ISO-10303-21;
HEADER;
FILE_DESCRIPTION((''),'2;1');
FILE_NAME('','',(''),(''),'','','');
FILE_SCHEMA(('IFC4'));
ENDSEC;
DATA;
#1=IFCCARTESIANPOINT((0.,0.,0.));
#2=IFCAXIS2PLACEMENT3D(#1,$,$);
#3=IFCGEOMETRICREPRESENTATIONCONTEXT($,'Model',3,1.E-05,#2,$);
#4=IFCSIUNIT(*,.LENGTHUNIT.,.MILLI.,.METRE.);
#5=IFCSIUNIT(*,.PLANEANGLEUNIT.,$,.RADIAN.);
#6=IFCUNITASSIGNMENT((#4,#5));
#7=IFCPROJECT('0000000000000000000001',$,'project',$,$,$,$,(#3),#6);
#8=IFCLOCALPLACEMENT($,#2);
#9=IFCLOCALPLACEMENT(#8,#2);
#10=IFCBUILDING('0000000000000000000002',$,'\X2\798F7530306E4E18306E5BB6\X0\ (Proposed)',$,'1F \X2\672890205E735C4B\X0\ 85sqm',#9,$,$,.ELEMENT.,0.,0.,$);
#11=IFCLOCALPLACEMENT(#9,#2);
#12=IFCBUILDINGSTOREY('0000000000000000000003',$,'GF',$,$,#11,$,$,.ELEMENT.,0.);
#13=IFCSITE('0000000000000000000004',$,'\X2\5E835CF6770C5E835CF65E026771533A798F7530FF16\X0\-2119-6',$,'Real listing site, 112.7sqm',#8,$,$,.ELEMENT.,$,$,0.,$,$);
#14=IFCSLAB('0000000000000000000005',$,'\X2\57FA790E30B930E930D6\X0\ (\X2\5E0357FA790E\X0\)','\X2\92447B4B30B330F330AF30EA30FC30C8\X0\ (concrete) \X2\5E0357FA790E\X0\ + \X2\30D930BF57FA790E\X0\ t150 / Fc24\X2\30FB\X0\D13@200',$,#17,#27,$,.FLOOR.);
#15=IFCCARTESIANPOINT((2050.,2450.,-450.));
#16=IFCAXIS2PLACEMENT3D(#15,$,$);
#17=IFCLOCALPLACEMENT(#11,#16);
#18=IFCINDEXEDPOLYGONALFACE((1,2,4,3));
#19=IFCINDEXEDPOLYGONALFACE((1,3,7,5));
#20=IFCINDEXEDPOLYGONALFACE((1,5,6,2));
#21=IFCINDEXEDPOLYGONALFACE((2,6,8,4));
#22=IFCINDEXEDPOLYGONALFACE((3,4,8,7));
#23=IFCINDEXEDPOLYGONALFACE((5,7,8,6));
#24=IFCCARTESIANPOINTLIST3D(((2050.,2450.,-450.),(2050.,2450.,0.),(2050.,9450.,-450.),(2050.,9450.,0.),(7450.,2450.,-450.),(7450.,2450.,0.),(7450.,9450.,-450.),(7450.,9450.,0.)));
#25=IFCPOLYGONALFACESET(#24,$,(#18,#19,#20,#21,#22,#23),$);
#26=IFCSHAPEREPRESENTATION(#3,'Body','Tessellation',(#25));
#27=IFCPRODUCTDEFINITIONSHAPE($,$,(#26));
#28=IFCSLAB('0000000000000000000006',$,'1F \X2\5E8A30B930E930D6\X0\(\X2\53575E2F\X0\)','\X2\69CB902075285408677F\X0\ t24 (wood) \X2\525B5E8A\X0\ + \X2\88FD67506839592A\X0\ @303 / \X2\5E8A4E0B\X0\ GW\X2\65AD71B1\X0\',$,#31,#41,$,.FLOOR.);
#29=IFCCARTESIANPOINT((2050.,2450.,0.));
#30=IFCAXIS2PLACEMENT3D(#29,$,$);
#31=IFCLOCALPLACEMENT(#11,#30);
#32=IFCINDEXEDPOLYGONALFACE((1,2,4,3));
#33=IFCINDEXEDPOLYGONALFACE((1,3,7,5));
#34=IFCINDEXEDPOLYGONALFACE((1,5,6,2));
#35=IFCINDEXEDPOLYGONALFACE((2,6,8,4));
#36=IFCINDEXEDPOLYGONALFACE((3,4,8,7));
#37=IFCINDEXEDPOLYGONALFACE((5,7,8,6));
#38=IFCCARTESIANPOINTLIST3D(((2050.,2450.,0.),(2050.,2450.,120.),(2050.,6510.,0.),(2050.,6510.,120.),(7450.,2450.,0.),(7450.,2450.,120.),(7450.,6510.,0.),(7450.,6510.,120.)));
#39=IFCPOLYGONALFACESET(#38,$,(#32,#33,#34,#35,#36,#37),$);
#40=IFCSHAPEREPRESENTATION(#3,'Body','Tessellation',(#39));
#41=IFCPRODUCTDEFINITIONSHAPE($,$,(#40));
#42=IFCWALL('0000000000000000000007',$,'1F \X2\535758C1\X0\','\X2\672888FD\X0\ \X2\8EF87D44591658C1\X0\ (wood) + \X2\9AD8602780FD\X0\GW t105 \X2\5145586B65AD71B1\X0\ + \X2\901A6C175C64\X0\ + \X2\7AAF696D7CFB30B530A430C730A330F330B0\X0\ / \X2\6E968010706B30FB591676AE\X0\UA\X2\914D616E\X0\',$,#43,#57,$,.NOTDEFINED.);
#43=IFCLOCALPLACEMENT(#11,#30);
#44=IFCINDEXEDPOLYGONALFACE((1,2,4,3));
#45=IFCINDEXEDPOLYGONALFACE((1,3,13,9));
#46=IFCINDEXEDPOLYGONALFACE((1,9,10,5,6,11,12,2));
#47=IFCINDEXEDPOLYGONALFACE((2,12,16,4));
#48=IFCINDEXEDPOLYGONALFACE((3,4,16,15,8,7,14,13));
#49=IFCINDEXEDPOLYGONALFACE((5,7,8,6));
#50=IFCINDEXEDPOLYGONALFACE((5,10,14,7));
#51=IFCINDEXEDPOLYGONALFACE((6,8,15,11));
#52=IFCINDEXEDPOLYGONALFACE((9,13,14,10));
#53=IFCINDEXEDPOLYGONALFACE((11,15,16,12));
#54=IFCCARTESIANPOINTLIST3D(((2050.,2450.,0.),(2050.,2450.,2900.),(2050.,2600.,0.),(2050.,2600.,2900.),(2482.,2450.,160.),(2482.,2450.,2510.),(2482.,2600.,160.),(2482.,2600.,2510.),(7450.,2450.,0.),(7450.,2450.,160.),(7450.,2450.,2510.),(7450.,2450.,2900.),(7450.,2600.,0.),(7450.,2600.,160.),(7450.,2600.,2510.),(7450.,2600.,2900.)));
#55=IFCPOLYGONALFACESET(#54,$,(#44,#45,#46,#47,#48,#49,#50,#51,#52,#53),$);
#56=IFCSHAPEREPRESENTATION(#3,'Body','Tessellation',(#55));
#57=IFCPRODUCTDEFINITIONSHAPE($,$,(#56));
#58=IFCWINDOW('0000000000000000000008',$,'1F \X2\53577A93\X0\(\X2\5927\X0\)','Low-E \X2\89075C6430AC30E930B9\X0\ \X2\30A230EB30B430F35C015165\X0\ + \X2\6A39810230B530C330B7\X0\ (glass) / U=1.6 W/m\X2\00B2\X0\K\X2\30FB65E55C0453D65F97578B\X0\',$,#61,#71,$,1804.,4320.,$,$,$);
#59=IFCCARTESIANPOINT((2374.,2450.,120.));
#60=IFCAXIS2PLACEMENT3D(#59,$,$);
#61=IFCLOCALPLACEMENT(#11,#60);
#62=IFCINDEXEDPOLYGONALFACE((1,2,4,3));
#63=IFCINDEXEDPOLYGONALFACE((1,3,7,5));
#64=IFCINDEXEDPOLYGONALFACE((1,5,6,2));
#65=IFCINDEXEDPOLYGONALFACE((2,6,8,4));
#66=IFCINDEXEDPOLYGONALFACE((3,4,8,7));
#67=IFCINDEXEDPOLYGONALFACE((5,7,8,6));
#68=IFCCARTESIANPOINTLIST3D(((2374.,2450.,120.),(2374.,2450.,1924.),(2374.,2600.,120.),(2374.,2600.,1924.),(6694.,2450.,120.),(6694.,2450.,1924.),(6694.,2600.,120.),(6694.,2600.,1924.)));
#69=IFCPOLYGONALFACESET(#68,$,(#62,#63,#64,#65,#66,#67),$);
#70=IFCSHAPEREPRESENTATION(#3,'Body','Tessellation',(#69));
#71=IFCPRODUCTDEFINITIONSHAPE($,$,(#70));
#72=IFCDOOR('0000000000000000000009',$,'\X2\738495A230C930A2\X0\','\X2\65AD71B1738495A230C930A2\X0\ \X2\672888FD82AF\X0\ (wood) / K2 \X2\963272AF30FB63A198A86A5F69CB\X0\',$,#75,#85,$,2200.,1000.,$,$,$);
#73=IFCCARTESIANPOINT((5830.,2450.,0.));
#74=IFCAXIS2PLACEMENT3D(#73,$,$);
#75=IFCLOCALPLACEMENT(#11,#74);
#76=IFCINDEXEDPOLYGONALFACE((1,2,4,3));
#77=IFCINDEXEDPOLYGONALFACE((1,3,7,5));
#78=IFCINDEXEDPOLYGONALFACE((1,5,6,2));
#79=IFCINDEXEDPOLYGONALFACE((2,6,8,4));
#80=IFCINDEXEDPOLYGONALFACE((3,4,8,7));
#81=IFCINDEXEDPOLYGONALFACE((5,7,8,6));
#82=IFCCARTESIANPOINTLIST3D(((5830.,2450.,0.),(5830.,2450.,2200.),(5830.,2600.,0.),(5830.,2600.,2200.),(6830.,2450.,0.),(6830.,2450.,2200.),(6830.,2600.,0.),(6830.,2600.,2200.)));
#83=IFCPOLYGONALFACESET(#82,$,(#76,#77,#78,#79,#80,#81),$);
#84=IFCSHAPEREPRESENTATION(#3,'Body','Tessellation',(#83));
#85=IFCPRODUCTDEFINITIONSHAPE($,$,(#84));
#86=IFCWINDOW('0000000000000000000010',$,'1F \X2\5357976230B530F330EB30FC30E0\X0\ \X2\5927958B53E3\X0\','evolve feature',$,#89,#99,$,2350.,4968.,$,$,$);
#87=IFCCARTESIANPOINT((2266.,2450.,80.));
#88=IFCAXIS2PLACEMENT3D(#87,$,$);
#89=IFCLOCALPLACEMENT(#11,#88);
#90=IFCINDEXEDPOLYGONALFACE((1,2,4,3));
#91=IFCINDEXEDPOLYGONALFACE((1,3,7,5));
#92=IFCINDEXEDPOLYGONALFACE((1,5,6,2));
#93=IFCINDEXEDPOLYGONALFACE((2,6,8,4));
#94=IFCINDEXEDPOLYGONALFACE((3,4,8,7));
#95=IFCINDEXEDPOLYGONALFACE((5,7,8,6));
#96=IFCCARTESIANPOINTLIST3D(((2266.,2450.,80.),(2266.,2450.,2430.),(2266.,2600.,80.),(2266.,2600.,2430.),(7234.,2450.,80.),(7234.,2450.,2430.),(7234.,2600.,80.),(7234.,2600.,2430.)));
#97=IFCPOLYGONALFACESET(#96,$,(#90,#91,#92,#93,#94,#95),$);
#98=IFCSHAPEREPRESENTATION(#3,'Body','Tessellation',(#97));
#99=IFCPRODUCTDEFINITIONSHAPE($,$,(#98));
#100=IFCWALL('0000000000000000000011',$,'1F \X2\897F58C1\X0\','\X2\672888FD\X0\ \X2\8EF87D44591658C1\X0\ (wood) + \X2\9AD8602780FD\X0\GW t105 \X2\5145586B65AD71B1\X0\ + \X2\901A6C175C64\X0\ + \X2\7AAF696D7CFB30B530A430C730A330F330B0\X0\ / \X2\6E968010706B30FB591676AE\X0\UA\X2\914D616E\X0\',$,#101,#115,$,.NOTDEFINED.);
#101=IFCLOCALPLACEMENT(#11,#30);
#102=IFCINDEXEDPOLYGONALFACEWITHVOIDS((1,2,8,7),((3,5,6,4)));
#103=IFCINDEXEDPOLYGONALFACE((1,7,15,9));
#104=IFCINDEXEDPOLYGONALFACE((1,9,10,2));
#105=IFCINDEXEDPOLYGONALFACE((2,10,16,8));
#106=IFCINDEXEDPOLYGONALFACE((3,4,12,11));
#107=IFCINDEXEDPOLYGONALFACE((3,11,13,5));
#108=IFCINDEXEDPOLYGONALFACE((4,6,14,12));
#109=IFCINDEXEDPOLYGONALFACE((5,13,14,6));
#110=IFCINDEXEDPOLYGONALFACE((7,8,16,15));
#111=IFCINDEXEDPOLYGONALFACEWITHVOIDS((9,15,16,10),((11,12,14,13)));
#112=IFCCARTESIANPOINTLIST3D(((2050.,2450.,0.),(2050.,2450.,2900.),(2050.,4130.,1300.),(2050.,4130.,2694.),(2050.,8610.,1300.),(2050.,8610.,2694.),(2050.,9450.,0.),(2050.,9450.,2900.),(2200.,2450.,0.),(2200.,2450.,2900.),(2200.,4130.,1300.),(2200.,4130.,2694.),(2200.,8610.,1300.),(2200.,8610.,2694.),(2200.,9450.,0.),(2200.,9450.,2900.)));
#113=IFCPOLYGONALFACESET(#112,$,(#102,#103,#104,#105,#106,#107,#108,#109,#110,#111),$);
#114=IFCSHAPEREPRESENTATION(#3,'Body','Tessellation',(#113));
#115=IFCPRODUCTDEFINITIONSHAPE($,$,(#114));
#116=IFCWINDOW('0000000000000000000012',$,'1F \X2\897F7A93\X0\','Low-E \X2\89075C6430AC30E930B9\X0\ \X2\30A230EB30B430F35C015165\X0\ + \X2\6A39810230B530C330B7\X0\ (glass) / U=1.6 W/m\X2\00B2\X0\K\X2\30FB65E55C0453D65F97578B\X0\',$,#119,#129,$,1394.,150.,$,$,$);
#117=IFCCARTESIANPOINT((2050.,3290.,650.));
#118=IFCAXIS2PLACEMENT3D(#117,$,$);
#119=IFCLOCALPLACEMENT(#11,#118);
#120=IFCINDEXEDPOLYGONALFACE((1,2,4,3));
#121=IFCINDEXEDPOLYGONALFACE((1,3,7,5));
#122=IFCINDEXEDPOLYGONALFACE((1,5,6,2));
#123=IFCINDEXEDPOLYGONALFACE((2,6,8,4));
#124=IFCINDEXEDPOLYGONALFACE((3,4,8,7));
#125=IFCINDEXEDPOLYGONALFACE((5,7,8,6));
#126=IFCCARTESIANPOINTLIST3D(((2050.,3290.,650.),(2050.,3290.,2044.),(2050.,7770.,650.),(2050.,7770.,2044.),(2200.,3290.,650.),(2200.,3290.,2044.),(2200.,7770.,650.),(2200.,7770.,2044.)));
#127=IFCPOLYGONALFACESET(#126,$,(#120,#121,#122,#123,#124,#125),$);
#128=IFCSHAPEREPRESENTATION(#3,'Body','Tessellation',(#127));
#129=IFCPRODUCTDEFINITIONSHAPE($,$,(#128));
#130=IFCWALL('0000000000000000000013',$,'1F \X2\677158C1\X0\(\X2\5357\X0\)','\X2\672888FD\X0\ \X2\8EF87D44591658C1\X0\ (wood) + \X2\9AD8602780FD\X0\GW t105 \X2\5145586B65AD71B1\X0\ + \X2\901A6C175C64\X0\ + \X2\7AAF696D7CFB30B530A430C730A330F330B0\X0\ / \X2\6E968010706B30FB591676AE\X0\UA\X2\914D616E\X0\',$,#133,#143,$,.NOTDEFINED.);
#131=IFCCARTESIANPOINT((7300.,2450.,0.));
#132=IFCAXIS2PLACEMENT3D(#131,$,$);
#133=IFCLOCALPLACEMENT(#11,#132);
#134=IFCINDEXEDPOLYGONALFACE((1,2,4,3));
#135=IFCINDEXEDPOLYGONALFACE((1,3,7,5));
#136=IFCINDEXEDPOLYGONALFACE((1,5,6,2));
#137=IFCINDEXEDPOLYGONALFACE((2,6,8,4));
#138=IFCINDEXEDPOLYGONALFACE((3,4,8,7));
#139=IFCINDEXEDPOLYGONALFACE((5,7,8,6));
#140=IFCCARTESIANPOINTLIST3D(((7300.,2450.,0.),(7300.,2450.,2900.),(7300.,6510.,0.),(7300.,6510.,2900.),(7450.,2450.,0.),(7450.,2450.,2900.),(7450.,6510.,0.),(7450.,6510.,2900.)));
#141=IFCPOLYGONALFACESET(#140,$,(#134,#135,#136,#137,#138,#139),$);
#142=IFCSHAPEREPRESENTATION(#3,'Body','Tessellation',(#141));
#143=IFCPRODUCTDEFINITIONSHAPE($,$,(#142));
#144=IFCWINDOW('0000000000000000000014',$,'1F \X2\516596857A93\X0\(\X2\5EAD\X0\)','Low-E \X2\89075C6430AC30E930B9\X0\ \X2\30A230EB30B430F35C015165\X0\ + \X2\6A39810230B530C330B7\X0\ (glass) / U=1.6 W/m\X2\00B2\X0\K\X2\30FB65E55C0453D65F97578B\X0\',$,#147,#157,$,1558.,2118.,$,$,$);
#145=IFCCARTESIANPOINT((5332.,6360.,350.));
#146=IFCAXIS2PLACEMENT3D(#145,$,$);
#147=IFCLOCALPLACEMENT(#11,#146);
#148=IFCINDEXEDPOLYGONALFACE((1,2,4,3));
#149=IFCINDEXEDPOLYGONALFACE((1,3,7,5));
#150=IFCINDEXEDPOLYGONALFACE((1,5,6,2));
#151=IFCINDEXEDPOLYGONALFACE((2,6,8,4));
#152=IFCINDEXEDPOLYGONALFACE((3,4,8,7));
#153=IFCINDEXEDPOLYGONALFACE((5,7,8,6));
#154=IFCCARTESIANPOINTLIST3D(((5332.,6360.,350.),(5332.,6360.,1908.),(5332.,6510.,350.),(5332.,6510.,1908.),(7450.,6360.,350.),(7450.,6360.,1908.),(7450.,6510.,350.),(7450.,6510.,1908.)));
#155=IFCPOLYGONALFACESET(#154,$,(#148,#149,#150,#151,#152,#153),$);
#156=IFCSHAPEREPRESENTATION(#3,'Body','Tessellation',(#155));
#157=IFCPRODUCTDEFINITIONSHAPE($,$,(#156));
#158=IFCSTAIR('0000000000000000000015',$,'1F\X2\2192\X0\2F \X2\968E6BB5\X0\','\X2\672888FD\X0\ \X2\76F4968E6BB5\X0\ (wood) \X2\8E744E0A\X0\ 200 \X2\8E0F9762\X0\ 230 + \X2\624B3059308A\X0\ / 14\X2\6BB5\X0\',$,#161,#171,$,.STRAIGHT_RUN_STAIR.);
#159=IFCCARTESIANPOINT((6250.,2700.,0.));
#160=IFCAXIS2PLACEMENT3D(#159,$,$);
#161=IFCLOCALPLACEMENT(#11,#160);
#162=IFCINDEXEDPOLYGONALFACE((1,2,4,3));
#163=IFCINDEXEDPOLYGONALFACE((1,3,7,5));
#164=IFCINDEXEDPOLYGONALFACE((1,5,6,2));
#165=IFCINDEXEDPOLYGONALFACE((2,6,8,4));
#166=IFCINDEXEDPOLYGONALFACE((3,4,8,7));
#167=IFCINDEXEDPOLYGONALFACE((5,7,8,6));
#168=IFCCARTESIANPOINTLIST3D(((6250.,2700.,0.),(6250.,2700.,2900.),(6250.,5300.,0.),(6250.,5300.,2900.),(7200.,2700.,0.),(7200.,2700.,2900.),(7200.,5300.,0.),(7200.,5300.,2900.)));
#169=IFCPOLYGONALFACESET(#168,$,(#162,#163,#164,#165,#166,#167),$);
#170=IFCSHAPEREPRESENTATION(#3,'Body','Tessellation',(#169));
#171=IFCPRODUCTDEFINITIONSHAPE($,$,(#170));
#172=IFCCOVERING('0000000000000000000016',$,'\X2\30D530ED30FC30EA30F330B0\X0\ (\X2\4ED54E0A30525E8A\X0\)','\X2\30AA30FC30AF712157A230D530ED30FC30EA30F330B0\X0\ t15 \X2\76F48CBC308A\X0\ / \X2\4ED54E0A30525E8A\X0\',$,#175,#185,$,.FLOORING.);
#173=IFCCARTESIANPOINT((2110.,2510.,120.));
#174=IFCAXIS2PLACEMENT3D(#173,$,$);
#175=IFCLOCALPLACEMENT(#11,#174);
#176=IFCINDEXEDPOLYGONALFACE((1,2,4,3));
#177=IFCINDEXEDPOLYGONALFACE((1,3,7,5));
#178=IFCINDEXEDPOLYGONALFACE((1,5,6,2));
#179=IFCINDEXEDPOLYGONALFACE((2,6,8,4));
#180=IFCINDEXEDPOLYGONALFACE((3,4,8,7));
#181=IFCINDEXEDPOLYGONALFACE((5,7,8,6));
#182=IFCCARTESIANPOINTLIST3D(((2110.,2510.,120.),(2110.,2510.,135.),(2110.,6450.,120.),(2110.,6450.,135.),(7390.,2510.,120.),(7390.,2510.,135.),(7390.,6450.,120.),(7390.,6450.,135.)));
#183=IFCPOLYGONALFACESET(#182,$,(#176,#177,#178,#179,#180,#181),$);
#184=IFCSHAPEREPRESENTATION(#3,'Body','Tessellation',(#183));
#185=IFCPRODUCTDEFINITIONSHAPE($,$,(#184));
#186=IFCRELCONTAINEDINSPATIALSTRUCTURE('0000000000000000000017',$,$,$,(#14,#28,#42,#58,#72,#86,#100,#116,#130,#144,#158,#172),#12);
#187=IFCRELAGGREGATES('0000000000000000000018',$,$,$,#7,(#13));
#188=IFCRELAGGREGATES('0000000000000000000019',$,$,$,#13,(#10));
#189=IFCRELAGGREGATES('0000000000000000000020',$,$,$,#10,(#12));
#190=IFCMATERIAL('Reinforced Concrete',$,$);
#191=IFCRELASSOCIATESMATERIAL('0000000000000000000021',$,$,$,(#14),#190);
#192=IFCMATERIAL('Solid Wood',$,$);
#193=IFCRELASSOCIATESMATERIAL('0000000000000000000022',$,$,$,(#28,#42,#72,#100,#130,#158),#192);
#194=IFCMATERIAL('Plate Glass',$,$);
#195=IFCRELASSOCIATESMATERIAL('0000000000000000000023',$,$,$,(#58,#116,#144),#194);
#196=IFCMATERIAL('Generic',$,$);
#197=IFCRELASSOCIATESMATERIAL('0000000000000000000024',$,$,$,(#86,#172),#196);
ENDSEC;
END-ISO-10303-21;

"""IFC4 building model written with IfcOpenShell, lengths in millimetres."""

from ifc_helpers import new_model, si_unit, frame, frame_2d, origin, place, context, project, spatial, rectangle, extrude, material, element, fill, save


model = new_model("IFC4")

# Units and contexts
model_context = context("Model", 3, precision=1e-05, world=origin())
ifc_project = project(units=[si_unit("LENGTHUNIT", "METRE", prefix="MILLI"), si_unit("PLANEANGLEUNIT", "RADIAN")], contexts=[model_context])

# Site, building, storey
site_placement = place(None, origin())
site = spatial("IfcSite", under=ifc_project, at=site_placement, Name="広島県広島市東区福田６-2119-6", ObjectType="Real listing site, 112.7sqm", CompositionType="ELEMENT", RefElevation=0.0)
building_placement = place(site_placement, origin())
building = spatial("IfcBuilding", under=site, at=building_placement, Name="福田の丘の家 (Proposed)", ObjectType="1F 木造平屋 85sqm", CompositionType="ELEMENT", ElevationOfRefHeight=0.0, ElevationOfTerrain=0.0)
storey_placement = place(building_placement, origin())
storey = spatial("IfcBuildingStorey", under=building, at=storey_placement, Name="GF", CompositionType="ELEMENT", Elevation=0.0)

# Slabs
ifc_material_1 = material(Name="Reinforced Concrete")
slab_1_placement = place(storey_placement, frame((2050.0, 2450.0, -450.0)))
element("IfcSlab", 1, at=slab_1_placement, inside=storey, material=ifc_material_1, Name="基礎スラブ (布基礎)", Description="鉄筋コンクリート (concrete) 布基礎 + ベタ基礎 t150 / Fc24・D13@200", PredefinedType="FLOOR", context=model_context, shape_type="SweptSolid", body=[
    extrude(rectangle(XDim=5400.0, YDim=7000.0, at=frame_2d((2700.0, 3500.0))), frame((2050.0, 2450.0, -450.0)), (0.0, 0.0, 1.0), 450.0),
])
ifc_material_2 = material(Name="Solid Wood")
slab_2_placement = place(storey_placement, frame((2050.0, 2450.0, 0.0)))
element("IfcSlab", 2, at=slab_2_placement, inside=storey, material=ifc_material_2, Name="1F 床スラブ(南帯)", Description="構造用合板 t24 (wood) 剛床 + 製材根太 @303 / 床下 GW断熱", PredefinedType="FLOOR", context=model_context, shape_type="SweptSolid", body=[
    extrude(rectangle(XDim=5400.0, YDim=4060.0, at=frame_2d((2700.0, 2030.0))), frame((2050.0, 2450.0, 0.0)), (0.0, 0.0, 1.0), 120.0),
])

# Wall, openings, windows, door
wall_1_placement = place(storey_placement, frame((2050.0, 2450.0, 0.0)))
wall_1 = element("IfcWall", 3, at=wall_1_placement, inside=storey, material=ifc_material_2, Name="1F 南壁", Description="木製 軸組外壁 (wood) + 高性能GW t105 充填断熱 + 通気層 + 窯業系サイディング / 準耐火・外皮UA配慮", PredefinedType="NOTDEFINED", context=model_context, shape_type="SweptSolid", body=[
    extrude(rectangle(XDim=5400.0, YDim=150.0, at=frame_2d((2700.0, 75.0))), frame((2050.0, 2450.0, 0.0)), (0.0, 0.0, 1.0), 2900.0),
])
opening_1_placement = place(storey_placement, frame((2374.0, 2450.0, 120.0)))
opening_1 = element("IfcOpeningElement", 4, at=opening_1_placement, cuts=wall_1, PredefinedType="NOTDEFINED", context=model_context, shape_type="SweptSolid", body=[
    extrude(rectangle(XDim=4320.0, YDim=150.0, at=frame_2d((2160.0, 75.0))), frame((2374.0, 2450.0, 120.0)), (0.0, 0.0, 1.0), 1804.0),
])
opening_2_placement = place(storey_placement, frame((5830.0, 2450.0, 0.0)))
opening_2 = element("IfcOpeningElement", 5, at=opening_2_placement, cuts=wall_1, PredefinedType="NOTDEFINED", context=model_context, shape_type="SweptSolid", body=[
    extrude(rectangle(XDim=1000.0, YDim=150.0, at=frame_2d((500.0, 75.0))), frame((5830.0, 2450.0, 0.0)), (0.0, 0.0, 1.0), 2200.0),
])
opening_3_placement = place(storey_placement, frame((2266.0, 2450.0, 80.0)))
opening_3 = element("IfcOpeningElement", 6, at=opening_3_placement, cuts=wall_1, PredefinedType="NOTDEFINED", context=model_context, shape_type="SweptSolid", body=[
    extrude(rectangle(XDim=4968.0, YDim=150.0, at=frame_2d((2484.0, 75.0))), frame((2266.0, 2450.0, 80.0)), (0.0, 0.0, 1.0), 2350.0),
])
ifc_material_3 = material(Name="Plate Glass")
window_1_placement = place(storey_placement, frame((2374.0, 2450.0, 120.0)))
window_1 = element("IfcWindow", 7, at=window_1_placement, inside=storey, material=ifc_material_3, Name="1F 南窓(大)", Description="Low-E 複層ガラス アルゴン封入 + 樹脂サッシ (glass) / U=1.6 W/m²K・日射取得型", OverallHeight=1804.0, OverallWidth=4320.0, context=model_context, shape_type="SweptSolid", body=[
    extrude(rectangle(XDim=4320.0, YDim=150.0, at=frame_2d((2160.0, 75.0))), frame((2374.0, 2450.0, 120.0)), (0.0, 0.0, 1.0), 1804.0),
])
fill(opening_1, window_1)
door_1_placement = place(storey_placement, frame((5830.0, 2450.0, 0.0)))
door_1 = element("IfcDoor", 8, at=door_1_placement, inside=storey, material=ifc_material_2, Name="玄関ドア", Description="断熱玄関ドア 木製芯 (wood) / K2 防犯・採風機構", OverallHeight=2200.0, OverallWidth=1000.0, context=model_context, shape_type="SweptSolid", body=[
    extrude(rectangle(XDim=1000.0, YDim=150.0, at=frame_2d((500.0, 75.0))), frame((5830.0, 2450.0, 0.0)), (0.0, 0.0, 1.0), 2200.0),
])
fill(opening_2, door_1)
ifc_material_4 = material(Name="Generic")
window_2_placement = place(storey_placement, frame((2266.0, 2450.0, 80.0)))
window_2 = element("IfcWindow", 9, at=window_2_placement, inside=storey, material=ifc_material_4, Name="1F 南面サンルーム 大開口", Description="evolve feature", OverallHeight=2350.0, OverallWidth=4968.0, context=model_context, shape_type="SweptSolid", body=[
    extrude(rectangle(XDim=4968.0, YDim=150.0, at=frame_2d((2484.0, 75.0))), frame((2266.0, 2450.0, 80.0)), (0.0, 0.0, 1.0), 2350.0),
])
fill(opening_3, window_2)

# Walls, openings, windows
wall_2_placement = place(storey_placement, frame((2050.0, 2450.0, 0.0)))
wall_2 = element("IfcWall", 10, at=wall_2_placement, inside=storey, material=ifc_material_2, Name="1F 西壁", Description="木製 軸組外壁 (wood) + 高性能GW t105 充填断熱 + 通気層 + 窯業系サイディング / 準耐火・外皮UA配慮", PredefinedType="NOTDEFINED", context=model_context, shape_type="SweptSolid", body=[
    extrude(rectangle(XDim=150.0, YDim=7000.0, at=frame_2d((75.0, 3500.0))), frame((2050.0, 2450.0, 0.0)), (0.0, 0.0, 1.0), 2900.0),
])
opening_4_placement = place(storey_placement, frame((2050.0, 3290.0, 650.0)))
opening_4 = element("IfcOpeningElement", 11, at=opening_4_placement, cuts=wall_2, PredefinedType="NOTDEFINED", context=model_context, shape_type="SweptSolid", body=[
    extrude(rectangle(XDim=150.0, YDim=4480.0, at=frame_2d((75.0, 2240.0))), frame((2050.0, 3290.0, 650.0)), (0.0, 0.0, 1.0), 1394.0),
])
window_3_placement = place(storey_placement, frame((2050.0, 3290.0, 650.0)))
window_3 = element("IfcWindow", 12, at=window_3_placement, inside=storey, material=ifc_material_3, Name="1F 西窓", Description="Low-E 複層ガラス アルゴン封入 + 樹脂サッシ (glass) / U=1.6 W/m²K・日射取得型", OverallHeight=1394.0, OverallWidth=150.0, context=model_context, shape_type="SweptSolid", body=[
    extrude(rectangle(XDim=150.0, YDim=4480.0, at=frame_2d((75.0, 2240.0))), frame((2050.0, 3290.0, 650.0)), (0.0, 0.0, 1.0), 1394.0),
])
fill(opening_4, window_3)
wall_3_placement = place(storey_placement, frame((7300.0, 2450.0, 0.0)))
wall_3 = element("IfcWall", 13, at=wall_3_placement, inside=storey, material=ifc_material_2, Name="1F 東壁(南)", Description="木製 軸組外壁 (wood) + 高性能GW t105 充填断熱 + 通気層 + 窯業系サイディング / 準耐火・外皮UA配慮", PredefinedType="NOTDEFINED", context=model_context, shape_type="SweptSolid", body=[
    extrude(rectangle(XDim=150.0, YDim=4060.0, at=frame_2d((75.0, 2030.0))), frame((7300.0, 2450.0, 0.0)), (0.0, 0.0, 1.0), 2900.0),
])
opening_5_placement = place(storey_placement, frame((5332.0, 6360.0, 350.0)))
opening_5 = element("IfcOpeningElement", 14, at=opening_5_placement, cuts=wall_3, PredefinedType="NOTDEFINED", context=model_context, shape_type="SweptSolid", body=[
    extrude(rectangle(XDim=2118.0, YDim=150.0, at=frame_2d((1059.0, 75.0))), frame((5332.0, 6360.0, 350.0)), (0.0, 0.0, 1.0), 1558.0),
])
window_4_placement = place(storey_placement, frame((5332.0, 6360.0, 350.0)))
window_4 = element("IfcWindow", 15, at=window_4_placement, inside=storey, material=ifc_material_3, Name="1F 入隅窓(庭)", Description="Low-E 複層ガラス アルゴン封入 + 樹脂サッシ (glass) / U=1.6 W/m²K・日射取得型", OverallHeight=1558.0, OverallWidth=2118.0, context=model_context, shape_type="SweptSolid", body=[
    extrude(rectangle(XDim=2118.0, YDim=150.0, at=frame_2d((1059.0, 75.0))), frame((5332.0, 6360.0, 350.0)), (0.0, 0.0, 1.0), 1558.0),
])
fill(opening_5, window_4)

# Stair
stair_placement = place(storey_placement, frame((6250.0, 2700.0, 0.0)))
element("IfcStair", 16, at=stair_placement, inside=storey, material=ifc_material_2, Name="1F→2F 階段", Description="木製 直階段 (wood) 蹴上 200 踏面 230 + 手すり / 14段", PredefinedType="STRAIGHT_RUN_STAIR", context=model_context, shape_type="SweptSolid", body=[
    extrude(rectangle(XDim=950.0, YDim=2600.0, at=frame_2d((475.0, 1300.0))), frame((6250.0, 2700.0, 0.0)), (0.0, 0.0, 1.0), 2900.0),
])

# Covering
covering_placement = place(storey_placement, frame((2110.0, 2510.0, 120.0)))
element("IfcCovering", 17, at=covering_placement, inside=storey, material=ifc_material_4, Name="フローリング (仕上げ床)", Description="オーク無垢フローリング t15 直貼り / 仕上げ床", PredefinedType="FLOORING", context=model_context, shape_type="SweptSolid", body=[
    extrude(rectangle(XDim=5280.0, YDim=3940.0, at=frame_2d((2640.0, 1970.0))), frame((2110.0, 2510.0, 120.0)), (0.0, 0.0, 1.0), 15.0),
])

save(model, "model.ifc")
